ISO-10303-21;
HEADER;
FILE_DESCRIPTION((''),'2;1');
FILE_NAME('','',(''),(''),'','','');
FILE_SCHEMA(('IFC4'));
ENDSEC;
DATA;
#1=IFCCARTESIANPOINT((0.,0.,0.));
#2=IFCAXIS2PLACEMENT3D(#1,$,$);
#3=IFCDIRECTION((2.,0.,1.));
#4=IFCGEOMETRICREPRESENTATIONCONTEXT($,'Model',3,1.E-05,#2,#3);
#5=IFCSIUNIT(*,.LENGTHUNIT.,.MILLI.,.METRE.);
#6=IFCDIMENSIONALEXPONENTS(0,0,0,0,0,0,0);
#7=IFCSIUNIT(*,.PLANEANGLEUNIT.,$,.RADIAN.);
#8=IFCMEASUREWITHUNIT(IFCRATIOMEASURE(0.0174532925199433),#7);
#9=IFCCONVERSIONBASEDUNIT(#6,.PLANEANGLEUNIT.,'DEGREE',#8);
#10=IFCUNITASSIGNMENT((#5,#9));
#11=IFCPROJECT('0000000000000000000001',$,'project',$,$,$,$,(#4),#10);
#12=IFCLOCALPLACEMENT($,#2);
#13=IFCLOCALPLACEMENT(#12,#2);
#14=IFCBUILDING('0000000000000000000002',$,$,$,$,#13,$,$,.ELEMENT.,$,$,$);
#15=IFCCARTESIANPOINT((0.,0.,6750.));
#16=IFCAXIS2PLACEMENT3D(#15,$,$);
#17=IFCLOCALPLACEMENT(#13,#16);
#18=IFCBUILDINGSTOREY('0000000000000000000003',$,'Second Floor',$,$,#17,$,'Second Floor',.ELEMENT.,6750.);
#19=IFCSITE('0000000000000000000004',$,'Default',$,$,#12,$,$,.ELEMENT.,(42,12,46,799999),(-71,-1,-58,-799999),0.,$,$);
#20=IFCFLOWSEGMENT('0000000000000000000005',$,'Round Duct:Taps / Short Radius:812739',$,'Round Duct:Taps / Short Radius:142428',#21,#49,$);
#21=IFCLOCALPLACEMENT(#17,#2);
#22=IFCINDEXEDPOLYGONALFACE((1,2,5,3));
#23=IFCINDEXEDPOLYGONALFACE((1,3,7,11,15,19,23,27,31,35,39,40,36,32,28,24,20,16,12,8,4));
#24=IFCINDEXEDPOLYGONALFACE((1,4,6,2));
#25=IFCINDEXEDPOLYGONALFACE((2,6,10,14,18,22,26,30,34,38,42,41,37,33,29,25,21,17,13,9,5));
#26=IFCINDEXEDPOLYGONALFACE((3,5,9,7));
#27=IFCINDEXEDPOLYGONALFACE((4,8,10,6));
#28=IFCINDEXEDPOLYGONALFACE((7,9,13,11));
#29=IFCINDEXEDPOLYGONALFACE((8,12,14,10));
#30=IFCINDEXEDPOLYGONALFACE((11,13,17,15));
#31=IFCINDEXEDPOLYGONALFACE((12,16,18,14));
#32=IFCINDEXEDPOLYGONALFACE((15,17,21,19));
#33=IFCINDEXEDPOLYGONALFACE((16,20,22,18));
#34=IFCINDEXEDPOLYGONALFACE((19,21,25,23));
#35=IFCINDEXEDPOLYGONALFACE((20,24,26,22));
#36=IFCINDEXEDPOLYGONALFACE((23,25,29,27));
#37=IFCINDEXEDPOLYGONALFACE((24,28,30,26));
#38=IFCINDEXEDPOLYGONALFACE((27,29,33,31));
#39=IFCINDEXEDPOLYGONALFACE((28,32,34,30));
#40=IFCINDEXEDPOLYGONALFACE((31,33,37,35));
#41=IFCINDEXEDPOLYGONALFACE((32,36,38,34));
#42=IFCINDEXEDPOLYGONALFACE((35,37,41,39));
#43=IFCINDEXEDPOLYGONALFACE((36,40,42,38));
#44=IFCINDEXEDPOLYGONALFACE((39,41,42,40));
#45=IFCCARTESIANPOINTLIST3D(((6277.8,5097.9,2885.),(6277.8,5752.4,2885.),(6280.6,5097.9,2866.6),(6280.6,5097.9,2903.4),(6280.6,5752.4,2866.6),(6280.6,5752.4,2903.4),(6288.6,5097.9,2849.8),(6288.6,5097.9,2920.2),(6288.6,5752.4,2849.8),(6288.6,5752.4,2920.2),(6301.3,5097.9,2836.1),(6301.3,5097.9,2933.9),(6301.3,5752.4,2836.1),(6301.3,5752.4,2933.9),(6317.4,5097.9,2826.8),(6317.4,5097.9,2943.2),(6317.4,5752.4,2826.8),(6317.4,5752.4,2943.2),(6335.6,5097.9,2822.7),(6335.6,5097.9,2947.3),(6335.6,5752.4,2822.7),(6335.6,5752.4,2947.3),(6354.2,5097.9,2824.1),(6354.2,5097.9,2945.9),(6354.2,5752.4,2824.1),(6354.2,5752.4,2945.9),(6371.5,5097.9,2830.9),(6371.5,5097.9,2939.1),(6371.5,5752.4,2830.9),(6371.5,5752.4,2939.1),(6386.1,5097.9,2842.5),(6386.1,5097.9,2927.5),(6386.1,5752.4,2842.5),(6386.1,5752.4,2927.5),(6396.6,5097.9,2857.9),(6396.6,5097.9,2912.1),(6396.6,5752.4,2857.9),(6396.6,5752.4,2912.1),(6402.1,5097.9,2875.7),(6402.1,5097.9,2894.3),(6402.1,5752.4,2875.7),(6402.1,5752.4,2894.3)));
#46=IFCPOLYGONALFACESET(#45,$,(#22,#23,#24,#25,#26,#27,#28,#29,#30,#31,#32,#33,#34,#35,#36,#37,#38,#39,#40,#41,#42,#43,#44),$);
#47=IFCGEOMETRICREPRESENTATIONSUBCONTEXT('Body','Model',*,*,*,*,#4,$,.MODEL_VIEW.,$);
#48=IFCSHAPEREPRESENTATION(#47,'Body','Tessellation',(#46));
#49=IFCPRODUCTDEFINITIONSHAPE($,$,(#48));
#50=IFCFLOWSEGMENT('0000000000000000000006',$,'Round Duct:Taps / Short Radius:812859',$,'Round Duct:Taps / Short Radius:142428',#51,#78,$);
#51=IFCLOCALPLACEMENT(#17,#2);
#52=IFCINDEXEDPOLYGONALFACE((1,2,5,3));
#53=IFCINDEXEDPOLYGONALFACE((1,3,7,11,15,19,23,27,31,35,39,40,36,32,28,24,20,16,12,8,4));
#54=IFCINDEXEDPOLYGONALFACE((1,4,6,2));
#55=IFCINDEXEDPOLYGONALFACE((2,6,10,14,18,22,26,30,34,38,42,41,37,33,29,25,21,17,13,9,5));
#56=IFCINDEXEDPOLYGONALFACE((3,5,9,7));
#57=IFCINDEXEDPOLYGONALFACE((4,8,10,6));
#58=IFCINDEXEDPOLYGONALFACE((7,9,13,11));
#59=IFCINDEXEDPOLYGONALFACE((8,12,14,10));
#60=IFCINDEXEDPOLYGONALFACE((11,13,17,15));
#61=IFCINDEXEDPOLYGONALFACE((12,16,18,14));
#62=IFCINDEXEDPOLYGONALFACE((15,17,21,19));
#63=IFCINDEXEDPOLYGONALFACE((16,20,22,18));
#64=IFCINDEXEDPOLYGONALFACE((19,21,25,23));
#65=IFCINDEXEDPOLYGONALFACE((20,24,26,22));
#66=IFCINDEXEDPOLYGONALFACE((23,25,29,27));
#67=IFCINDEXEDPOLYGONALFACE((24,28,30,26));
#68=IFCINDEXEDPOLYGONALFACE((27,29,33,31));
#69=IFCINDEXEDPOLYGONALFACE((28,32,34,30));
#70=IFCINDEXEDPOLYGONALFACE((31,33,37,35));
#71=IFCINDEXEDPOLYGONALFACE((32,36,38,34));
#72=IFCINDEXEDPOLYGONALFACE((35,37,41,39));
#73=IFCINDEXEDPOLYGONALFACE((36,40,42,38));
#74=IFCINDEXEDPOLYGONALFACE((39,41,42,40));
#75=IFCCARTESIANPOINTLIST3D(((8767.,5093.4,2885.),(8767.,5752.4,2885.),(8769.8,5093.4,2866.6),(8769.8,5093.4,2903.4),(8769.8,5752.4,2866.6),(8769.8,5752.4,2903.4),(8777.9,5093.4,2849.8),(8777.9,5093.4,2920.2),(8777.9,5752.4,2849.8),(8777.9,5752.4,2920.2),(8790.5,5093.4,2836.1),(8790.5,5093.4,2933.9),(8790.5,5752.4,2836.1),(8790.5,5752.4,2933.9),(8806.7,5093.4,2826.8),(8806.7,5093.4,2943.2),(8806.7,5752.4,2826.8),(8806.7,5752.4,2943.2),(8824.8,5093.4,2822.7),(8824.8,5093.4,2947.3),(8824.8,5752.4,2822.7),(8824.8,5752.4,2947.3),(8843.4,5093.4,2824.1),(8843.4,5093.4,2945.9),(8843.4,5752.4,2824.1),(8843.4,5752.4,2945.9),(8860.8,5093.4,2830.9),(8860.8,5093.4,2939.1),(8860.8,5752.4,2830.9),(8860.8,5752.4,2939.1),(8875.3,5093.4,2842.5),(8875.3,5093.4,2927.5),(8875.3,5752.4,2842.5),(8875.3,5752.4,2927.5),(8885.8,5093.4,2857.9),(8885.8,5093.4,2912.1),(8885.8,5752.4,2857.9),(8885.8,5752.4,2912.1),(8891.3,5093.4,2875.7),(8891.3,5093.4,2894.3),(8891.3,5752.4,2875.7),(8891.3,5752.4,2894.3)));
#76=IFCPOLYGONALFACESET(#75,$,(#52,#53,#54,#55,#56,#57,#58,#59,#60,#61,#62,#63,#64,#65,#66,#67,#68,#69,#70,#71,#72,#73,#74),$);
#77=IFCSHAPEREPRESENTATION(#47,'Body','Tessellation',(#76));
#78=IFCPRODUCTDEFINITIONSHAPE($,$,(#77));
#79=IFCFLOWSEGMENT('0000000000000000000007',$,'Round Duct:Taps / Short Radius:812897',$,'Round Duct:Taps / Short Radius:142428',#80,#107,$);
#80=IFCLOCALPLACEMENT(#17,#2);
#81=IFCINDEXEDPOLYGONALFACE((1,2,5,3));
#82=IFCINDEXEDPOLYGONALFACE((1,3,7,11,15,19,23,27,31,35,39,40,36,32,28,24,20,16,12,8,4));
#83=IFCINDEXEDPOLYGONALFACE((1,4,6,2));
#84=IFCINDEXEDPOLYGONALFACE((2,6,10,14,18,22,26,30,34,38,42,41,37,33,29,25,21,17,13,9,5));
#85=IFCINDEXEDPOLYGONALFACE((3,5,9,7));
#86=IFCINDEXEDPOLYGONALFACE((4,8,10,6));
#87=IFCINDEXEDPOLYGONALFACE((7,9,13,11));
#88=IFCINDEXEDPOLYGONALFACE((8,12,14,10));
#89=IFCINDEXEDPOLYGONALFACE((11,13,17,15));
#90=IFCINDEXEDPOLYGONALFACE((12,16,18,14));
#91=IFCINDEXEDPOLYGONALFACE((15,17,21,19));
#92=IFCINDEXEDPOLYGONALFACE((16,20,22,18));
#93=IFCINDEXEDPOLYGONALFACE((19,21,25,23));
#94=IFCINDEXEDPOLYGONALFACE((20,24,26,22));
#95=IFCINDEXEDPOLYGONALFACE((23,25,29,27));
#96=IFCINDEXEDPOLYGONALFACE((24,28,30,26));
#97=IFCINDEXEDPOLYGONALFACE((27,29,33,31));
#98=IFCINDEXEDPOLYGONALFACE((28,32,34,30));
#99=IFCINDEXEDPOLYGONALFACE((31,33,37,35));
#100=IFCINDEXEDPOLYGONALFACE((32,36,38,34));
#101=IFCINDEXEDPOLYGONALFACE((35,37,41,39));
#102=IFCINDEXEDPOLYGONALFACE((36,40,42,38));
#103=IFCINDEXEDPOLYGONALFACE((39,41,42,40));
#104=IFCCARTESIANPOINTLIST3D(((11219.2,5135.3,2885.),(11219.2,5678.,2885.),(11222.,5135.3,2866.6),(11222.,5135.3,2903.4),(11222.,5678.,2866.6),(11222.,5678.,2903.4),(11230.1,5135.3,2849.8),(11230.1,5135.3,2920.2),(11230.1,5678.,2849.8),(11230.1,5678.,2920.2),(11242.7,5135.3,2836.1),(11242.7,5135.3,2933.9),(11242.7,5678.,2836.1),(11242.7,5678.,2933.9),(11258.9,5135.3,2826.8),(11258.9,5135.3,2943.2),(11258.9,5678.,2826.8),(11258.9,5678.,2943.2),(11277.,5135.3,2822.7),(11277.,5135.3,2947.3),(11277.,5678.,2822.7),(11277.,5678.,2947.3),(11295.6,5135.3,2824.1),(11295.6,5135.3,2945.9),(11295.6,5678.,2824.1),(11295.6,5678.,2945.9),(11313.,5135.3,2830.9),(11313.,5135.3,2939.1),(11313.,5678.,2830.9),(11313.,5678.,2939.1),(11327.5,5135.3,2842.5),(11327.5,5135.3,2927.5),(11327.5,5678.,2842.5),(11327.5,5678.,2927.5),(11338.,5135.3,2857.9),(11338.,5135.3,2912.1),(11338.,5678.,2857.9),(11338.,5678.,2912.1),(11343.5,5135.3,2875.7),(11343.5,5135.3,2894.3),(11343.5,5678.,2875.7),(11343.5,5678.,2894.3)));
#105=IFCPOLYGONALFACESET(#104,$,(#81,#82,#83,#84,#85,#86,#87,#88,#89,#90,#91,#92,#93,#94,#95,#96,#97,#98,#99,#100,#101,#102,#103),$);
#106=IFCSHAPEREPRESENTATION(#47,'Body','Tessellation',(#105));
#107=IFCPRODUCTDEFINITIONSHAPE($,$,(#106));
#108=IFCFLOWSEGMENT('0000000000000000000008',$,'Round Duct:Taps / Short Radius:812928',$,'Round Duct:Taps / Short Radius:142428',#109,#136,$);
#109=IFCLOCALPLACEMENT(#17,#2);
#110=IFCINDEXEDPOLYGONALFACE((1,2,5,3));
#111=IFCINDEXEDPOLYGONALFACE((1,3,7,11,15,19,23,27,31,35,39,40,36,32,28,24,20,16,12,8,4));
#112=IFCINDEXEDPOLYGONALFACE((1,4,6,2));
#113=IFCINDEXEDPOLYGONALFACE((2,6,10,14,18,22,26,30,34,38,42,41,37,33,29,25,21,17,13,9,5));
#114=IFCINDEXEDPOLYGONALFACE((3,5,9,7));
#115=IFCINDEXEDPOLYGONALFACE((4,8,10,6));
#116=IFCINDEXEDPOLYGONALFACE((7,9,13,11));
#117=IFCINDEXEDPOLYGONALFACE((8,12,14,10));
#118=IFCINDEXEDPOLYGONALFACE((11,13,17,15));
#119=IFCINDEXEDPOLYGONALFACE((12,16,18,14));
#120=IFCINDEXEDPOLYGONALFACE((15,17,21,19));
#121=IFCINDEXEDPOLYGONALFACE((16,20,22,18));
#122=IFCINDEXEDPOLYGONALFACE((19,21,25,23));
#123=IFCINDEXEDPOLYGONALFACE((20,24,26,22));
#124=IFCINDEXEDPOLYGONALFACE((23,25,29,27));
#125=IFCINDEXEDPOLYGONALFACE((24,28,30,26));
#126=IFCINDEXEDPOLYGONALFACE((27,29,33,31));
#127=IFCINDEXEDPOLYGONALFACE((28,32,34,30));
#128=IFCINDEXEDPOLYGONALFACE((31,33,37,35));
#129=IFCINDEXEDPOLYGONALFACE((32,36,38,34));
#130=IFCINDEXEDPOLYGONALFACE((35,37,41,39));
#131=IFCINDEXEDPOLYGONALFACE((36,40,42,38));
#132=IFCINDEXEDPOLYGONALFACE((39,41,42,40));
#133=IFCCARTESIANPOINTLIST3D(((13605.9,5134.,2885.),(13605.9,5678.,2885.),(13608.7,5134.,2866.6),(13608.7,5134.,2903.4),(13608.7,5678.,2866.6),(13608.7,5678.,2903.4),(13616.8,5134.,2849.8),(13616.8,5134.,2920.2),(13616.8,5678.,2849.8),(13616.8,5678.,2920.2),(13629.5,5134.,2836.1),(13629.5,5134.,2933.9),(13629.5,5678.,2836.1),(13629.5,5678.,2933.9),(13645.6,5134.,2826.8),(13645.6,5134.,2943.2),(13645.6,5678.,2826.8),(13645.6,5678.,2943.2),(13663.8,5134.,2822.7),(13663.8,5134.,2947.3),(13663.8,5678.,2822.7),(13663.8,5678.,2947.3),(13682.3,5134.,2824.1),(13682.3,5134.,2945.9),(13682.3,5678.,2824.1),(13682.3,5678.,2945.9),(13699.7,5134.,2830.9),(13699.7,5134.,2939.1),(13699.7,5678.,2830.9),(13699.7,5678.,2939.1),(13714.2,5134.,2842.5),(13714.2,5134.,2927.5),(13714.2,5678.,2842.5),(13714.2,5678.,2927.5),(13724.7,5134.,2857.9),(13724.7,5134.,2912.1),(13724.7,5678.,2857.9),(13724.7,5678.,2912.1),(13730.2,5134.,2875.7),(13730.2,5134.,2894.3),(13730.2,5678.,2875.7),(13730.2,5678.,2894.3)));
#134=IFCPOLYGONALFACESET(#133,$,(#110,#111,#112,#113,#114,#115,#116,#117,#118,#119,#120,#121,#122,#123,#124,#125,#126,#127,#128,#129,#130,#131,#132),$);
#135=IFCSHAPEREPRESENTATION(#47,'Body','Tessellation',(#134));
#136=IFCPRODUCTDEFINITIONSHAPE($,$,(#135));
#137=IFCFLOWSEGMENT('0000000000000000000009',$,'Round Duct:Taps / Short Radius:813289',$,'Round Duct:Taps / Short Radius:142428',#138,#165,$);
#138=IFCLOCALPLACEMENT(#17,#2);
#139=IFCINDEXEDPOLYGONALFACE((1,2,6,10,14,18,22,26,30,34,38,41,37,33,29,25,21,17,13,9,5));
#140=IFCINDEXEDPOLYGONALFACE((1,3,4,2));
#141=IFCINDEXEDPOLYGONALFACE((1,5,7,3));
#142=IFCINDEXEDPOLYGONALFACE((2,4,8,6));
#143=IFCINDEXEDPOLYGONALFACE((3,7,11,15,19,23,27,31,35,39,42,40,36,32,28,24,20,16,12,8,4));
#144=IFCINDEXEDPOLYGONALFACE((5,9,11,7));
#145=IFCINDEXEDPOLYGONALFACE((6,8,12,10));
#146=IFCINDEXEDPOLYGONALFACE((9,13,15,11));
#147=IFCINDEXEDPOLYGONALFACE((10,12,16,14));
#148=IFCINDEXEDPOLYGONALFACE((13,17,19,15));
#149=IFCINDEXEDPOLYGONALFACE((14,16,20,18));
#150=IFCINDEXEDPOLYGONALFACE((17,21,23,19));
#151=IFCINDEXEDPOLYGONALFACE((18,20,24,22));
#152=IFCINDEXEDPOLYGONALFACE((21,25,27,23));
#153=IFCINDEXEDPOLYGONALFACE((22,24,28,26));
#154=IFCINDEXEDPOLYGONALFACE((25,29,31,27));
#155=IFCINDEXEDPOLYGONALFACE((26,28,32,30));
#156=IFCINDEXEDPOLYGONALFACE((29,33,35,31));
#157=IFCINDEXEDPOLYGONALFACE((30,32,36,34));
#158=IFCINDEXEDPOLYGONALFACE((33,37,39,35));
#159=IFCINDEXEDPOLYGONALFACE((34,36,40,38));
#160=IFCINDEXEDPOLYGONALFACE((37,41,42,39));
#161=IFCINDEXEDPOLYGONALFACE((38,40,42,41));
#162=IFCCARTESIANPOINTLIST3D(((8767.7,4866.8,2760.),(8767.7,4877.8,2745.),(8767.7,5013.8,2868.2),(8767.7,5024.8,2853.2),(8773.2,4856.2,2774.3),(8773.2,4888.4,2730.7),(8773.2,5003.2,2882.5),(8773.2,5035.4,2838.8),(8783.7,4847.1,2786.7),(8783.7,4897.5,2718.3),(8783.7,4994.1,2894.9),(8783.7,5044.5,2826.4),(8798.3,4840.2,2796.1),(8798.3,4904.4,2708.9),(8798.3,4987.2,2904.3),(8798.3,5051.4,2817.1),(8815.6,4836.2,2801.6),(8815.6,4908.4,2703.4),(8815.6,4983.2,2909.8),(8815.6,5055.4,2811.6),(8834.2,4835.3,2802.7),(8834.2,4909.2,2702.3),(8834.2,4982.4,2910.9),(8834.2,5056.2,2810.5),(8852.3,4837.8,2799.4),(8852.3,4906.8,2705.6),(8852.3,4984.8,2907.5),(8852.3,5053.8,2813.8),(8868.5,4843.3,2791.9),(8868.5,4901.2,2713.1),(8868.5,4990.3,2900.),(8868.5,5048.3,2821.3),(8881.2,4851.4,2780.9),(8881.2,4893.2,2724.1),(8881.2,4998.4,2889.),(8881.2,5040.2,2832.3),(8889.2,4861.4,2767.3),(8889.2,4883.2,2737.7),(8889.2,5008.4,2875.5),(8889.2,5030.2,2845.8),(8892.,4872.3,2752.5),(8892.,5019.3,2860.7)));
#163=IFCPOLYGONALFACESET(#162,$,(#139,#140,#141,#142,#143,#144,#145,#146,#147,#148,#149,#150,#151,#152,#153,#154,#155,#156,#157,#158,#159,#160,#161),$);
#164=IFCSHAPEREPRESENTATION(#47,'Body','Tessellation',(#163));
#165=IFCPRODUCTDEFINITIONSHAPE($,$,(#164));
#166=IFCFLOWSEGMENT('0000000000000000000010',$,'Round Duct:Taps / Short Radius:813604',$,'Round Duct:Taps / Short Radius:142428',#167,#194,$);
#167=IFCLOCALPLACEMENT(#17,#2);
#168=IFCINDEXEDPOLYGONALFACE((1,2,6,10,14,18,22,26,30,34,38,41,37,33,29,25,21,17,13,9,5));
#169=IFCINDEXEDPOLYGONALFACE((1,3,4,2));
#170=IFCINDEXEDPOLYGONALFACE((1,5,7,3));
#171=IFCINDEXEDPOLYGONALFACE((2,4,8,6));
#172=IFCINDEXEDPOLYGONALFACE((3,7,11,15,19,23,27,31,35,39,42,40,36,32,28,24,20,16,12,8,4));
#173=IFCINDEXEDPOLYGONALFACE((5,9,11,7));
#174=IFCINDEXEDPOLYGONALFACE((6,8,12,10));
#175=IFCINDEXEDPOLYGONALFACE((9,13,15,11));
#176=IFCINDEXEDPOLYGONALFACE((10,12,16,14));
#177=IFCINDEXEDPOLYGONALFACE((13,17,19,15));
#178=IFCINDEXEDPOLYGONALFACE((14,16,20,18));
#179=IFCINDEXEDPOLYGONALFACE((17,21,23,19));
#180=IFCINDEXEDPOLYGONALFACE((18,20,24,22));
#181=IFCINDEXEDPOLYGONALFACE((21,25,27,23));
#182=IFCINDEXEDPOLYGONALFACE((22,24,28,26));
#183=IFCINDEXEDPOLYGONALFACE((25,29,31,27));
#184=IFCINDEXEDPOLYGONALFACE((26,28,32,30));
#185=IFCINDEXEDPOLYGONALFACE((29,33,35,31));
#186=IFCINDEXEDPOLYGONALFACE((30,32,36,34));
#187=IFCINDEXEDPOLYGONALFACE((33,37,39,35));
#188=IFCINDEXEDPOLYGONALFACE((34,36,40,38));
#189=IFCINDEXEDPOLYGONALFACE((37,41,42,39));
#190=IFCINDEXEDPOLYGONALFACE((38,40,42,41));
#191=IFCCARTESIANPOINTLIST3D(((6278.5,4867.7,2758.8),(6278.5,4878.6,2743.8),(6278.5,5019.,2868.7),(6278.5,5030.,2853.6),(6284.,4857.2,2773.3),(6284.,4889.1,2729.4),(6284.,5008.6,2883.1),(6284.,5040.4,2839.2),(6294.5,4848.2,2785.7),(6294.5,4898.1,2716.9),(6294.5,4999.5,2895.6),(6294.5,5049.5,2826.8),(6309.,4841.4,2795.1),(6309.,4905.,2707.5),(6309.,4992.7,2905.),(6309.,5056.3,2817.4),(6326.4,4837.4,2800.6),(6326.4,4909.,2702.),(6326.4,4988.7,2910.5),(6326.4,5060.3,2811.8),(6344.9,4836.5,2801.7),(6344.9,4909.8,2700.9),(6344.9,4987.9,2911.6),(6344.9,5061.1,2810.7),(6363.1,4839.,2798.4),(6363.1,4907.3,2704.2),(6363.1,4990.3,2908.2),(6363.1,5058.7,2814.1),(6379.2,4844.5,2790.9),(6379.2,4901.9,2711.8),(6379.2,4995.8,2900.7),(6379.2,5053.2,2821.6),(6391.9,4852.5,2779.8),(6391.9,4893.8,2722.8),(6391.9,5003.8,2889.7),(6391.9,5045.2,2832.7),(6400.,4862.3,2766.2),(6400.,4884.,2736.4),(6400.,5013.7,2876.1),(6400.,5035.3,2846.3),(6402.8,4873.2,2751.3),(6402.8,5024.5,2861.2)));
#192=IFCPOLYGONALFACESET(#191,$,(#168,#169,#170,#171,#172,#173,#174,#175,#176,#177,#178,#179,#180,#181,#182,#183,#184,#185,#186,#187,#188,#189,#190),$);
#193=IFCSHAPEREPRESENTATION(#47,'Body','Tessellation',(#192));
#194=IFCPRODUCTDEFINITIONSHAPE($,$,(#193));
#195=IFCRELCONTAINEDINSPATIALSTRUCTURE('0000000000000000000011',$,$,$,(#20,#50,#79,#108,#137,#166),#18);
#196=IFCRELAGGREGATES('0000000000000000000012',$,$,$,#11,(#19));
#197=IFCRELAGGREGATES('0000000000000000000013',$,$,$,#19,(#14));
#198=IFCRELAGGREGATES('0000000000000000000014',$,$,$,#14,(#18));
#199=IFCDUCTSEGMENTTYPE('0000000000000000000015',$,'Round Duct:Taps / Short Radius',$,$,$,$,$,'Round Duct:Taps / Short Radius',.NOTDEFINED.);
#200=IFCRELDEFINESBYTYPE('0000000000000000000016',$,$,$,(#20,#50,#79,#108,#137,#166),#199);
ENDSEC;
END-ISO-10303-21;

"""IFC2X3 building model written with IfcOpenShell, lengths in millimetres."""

from ifc_helpers import new_model, entity, si_unit, converted_unit, direction, frame, frame_2d, origin, place, context, subcontext, project, spatial, circle, extrude, type_object, element, save


model = new_model("IFC2X3")

# Units and contexts
model_context = context("Model", 3, precision=1e-05, world=origin(), true_north=direction((2.0, 0.0, 1.0)))
body_context = subcontext(model_context, "Body", "Model", "MODEL_VIEW")
ifc_project = project(units=[si_unit("LENGTHUNIT", "METRE", prefix="MILLI"), converted_unit("PLANEANGLEUNIT", "DEGREE", entity("IfcRatioMeasure", 0.0174532925199433), si_unit("PLANEANGLEUNIT", "RADIAN"), dimensions=[0, 0, 0, 0, 0, 0, 0])], contexts=[model_context])

# Site, building, storey
site_placement = place(None, origin())
site = spatial("IfcSite", under=ifc_project, at=site_placement, Name="Default", CompositionType="ELEMENT", RefLatitude=(42, 12, 46, 799999), RefLongitude=(-71, -1, -58, -799999), RefElevation=0.0)
building_placement = place(site_placement, origin())
building = spatial("IfcBuilding", under=site, at=building_placement, CompositionType="ELEMENT")
storey_placement = place(building_placement, frame((0.0, 0.0, 6750.0)))
storey = spatial("IfcBuildingStorey", under=building, at=storey_placement, Name="Second Floor", LongName="Second Floor", CompositionType="ELEMENT", Elevation=6750.0)

# Flow segments
duct_segment_type = type_object("IfcDuctSegmentType", Name="Round Duct:Taps / Short Radius", ElementType="Round Duct:Taps / Short Radius", PredefinedType="NOTDEFINED")
flow_segment_1_placement = place(storey_placement, origin())
element("IfcFlowSegment", 1, at=flow_segment_1_placement, inside=storey, type_object=duct_segment_type, Name="Round Duct:Taps / Short Radius:812739", ObjectType="Round Duct:Taps / Short Radius:142428", context=body_context, shape_type="SweptSolid", body=[
    extrude(circle(Radius=62.5, at=frame_2d((0.0, 0.0), x_axis=(1.0, 0.0))), frame((6340.3, 5097.9, 2885.0), z_axis=(0.0, 1.0, 0.0), x_axis=(-1.0, 0.0, 0.0)), (0.0, 0.0, 1.0), 654.4),
])
flow_segment_2_placement = place(storey_placement, origin())
element("IfcFlowSegment", 2, at=flow_segment_2_placement, inside=storey, type_object=duct_segment_type, Name="Round Duct:Taps / Short Radius:812859", ObjectType="Round Duct:Taps / Short Radius:142428", context=body_context, shape_type="SweptSolid", body=[
    extrude(circle(Radius=62.5, at=frame_2d((0.0, 0.0), x_axis=(1.0, 0.0))), frame((8829.5, 5093.4, 2885.0), z_axis=(0.0, 1.0, 0.0), x_axis=(-1.0, 0.0, 0.0)), (0.0, 0.0, 1.0), 659.0),
])
flow_segment_3_placement = place(storey_placement, origin())
element("IfcFlowSegment", 3, at=flow_segment_3_placement, inside=storey, type_object=duct_segment_type, Name="Round Duct:Taps / Short Radius:812897", ObjectType="Round Duct:Taps / Short Radius:142428", context=body_context, shape_type="SweptSolid", body=[
    extrude(circle(Radius=62.5, at=frame_2d((0.0, 0.0), x_axis=(1.0, 0.0))), frame((11281.7, 5135.3, 2885.0), z_axis=(0.0, 1.0, 0.0), x_axis=(-1.0, 0.0, 0.0)), (0.0, 0.0, 1.0), 542.8),
])
flow_segment_4_placement = place(storey_placement, origin())
element("IfcFlowSegment", 4, at=flow_segment_4_placement, inside=storey, type_object=duct_segment_type, Name="Round Duct:Taps / Short Radius:812928", ObjectType="Round Duct:Taps / Short Radius:142428", context=body_context, shape_type="SweptSolid", body=[
    extrude(circle(Radius=62.5, at=frame_2d((0.0, 0.0), x_axis=(1.0, 0.0))), frame((13668.4, 5134.0, 2885.0), z_axis=(0.0, 1.0, 0.0), x_axis=(-1.0, 0.0, 0.0)), (0.0, 0.0, 1.0), 544.0),
])
flow_segment_5_placement = place(storey_placement, origin())
element("IfcFlowSegment", 5, at=flow_segment_5_placement, inside=storey, type_object=duct_segment_type, Name="Round Duct:Taps / Short Radius:813289", ObjectType="Round Duct:Taps / Short Radius:142428", context=body_context, shape_type="SweptSolid", body=[
    extrude(circle(Radius=62.5, at=frame_2d((0.0, 0.0), x_axis=(1.0, 0.0))), frame((8829.5, 4872.3, 2752.5), z_axis=(0.0, 0.805444, 0.592672), x_axis=(1.0, 0.0, 0.0)), (0.0, 0.0, 1.0), 182.5),
])
flow_segment_6_placement = place(storey_placement, origin())
element("IfcFlowSegment", 6, at=flow_segment_6_placement, inside=storey, type_object=duct_segment_type, Name="Round Duct:Taps / Short Radius:813604", ObjectType="Round Duct:Taps / Short Radius:142428", context=body_context, shape_type="SweptSolid", body=[
    extrude(circle(Radius=62.5, at=frame_2d((0.0, 0.0), x_axis=(1.0, 0.0))), frame((6340.3, 4873.2, 2751.3), z_axis=(0.0, 0.809293, 0.587405), x_axis=(1.0, 0.0, 0.0)), (0.0, 0.0, 1.0), 187.0),
])

save(model, "model.ifc")
